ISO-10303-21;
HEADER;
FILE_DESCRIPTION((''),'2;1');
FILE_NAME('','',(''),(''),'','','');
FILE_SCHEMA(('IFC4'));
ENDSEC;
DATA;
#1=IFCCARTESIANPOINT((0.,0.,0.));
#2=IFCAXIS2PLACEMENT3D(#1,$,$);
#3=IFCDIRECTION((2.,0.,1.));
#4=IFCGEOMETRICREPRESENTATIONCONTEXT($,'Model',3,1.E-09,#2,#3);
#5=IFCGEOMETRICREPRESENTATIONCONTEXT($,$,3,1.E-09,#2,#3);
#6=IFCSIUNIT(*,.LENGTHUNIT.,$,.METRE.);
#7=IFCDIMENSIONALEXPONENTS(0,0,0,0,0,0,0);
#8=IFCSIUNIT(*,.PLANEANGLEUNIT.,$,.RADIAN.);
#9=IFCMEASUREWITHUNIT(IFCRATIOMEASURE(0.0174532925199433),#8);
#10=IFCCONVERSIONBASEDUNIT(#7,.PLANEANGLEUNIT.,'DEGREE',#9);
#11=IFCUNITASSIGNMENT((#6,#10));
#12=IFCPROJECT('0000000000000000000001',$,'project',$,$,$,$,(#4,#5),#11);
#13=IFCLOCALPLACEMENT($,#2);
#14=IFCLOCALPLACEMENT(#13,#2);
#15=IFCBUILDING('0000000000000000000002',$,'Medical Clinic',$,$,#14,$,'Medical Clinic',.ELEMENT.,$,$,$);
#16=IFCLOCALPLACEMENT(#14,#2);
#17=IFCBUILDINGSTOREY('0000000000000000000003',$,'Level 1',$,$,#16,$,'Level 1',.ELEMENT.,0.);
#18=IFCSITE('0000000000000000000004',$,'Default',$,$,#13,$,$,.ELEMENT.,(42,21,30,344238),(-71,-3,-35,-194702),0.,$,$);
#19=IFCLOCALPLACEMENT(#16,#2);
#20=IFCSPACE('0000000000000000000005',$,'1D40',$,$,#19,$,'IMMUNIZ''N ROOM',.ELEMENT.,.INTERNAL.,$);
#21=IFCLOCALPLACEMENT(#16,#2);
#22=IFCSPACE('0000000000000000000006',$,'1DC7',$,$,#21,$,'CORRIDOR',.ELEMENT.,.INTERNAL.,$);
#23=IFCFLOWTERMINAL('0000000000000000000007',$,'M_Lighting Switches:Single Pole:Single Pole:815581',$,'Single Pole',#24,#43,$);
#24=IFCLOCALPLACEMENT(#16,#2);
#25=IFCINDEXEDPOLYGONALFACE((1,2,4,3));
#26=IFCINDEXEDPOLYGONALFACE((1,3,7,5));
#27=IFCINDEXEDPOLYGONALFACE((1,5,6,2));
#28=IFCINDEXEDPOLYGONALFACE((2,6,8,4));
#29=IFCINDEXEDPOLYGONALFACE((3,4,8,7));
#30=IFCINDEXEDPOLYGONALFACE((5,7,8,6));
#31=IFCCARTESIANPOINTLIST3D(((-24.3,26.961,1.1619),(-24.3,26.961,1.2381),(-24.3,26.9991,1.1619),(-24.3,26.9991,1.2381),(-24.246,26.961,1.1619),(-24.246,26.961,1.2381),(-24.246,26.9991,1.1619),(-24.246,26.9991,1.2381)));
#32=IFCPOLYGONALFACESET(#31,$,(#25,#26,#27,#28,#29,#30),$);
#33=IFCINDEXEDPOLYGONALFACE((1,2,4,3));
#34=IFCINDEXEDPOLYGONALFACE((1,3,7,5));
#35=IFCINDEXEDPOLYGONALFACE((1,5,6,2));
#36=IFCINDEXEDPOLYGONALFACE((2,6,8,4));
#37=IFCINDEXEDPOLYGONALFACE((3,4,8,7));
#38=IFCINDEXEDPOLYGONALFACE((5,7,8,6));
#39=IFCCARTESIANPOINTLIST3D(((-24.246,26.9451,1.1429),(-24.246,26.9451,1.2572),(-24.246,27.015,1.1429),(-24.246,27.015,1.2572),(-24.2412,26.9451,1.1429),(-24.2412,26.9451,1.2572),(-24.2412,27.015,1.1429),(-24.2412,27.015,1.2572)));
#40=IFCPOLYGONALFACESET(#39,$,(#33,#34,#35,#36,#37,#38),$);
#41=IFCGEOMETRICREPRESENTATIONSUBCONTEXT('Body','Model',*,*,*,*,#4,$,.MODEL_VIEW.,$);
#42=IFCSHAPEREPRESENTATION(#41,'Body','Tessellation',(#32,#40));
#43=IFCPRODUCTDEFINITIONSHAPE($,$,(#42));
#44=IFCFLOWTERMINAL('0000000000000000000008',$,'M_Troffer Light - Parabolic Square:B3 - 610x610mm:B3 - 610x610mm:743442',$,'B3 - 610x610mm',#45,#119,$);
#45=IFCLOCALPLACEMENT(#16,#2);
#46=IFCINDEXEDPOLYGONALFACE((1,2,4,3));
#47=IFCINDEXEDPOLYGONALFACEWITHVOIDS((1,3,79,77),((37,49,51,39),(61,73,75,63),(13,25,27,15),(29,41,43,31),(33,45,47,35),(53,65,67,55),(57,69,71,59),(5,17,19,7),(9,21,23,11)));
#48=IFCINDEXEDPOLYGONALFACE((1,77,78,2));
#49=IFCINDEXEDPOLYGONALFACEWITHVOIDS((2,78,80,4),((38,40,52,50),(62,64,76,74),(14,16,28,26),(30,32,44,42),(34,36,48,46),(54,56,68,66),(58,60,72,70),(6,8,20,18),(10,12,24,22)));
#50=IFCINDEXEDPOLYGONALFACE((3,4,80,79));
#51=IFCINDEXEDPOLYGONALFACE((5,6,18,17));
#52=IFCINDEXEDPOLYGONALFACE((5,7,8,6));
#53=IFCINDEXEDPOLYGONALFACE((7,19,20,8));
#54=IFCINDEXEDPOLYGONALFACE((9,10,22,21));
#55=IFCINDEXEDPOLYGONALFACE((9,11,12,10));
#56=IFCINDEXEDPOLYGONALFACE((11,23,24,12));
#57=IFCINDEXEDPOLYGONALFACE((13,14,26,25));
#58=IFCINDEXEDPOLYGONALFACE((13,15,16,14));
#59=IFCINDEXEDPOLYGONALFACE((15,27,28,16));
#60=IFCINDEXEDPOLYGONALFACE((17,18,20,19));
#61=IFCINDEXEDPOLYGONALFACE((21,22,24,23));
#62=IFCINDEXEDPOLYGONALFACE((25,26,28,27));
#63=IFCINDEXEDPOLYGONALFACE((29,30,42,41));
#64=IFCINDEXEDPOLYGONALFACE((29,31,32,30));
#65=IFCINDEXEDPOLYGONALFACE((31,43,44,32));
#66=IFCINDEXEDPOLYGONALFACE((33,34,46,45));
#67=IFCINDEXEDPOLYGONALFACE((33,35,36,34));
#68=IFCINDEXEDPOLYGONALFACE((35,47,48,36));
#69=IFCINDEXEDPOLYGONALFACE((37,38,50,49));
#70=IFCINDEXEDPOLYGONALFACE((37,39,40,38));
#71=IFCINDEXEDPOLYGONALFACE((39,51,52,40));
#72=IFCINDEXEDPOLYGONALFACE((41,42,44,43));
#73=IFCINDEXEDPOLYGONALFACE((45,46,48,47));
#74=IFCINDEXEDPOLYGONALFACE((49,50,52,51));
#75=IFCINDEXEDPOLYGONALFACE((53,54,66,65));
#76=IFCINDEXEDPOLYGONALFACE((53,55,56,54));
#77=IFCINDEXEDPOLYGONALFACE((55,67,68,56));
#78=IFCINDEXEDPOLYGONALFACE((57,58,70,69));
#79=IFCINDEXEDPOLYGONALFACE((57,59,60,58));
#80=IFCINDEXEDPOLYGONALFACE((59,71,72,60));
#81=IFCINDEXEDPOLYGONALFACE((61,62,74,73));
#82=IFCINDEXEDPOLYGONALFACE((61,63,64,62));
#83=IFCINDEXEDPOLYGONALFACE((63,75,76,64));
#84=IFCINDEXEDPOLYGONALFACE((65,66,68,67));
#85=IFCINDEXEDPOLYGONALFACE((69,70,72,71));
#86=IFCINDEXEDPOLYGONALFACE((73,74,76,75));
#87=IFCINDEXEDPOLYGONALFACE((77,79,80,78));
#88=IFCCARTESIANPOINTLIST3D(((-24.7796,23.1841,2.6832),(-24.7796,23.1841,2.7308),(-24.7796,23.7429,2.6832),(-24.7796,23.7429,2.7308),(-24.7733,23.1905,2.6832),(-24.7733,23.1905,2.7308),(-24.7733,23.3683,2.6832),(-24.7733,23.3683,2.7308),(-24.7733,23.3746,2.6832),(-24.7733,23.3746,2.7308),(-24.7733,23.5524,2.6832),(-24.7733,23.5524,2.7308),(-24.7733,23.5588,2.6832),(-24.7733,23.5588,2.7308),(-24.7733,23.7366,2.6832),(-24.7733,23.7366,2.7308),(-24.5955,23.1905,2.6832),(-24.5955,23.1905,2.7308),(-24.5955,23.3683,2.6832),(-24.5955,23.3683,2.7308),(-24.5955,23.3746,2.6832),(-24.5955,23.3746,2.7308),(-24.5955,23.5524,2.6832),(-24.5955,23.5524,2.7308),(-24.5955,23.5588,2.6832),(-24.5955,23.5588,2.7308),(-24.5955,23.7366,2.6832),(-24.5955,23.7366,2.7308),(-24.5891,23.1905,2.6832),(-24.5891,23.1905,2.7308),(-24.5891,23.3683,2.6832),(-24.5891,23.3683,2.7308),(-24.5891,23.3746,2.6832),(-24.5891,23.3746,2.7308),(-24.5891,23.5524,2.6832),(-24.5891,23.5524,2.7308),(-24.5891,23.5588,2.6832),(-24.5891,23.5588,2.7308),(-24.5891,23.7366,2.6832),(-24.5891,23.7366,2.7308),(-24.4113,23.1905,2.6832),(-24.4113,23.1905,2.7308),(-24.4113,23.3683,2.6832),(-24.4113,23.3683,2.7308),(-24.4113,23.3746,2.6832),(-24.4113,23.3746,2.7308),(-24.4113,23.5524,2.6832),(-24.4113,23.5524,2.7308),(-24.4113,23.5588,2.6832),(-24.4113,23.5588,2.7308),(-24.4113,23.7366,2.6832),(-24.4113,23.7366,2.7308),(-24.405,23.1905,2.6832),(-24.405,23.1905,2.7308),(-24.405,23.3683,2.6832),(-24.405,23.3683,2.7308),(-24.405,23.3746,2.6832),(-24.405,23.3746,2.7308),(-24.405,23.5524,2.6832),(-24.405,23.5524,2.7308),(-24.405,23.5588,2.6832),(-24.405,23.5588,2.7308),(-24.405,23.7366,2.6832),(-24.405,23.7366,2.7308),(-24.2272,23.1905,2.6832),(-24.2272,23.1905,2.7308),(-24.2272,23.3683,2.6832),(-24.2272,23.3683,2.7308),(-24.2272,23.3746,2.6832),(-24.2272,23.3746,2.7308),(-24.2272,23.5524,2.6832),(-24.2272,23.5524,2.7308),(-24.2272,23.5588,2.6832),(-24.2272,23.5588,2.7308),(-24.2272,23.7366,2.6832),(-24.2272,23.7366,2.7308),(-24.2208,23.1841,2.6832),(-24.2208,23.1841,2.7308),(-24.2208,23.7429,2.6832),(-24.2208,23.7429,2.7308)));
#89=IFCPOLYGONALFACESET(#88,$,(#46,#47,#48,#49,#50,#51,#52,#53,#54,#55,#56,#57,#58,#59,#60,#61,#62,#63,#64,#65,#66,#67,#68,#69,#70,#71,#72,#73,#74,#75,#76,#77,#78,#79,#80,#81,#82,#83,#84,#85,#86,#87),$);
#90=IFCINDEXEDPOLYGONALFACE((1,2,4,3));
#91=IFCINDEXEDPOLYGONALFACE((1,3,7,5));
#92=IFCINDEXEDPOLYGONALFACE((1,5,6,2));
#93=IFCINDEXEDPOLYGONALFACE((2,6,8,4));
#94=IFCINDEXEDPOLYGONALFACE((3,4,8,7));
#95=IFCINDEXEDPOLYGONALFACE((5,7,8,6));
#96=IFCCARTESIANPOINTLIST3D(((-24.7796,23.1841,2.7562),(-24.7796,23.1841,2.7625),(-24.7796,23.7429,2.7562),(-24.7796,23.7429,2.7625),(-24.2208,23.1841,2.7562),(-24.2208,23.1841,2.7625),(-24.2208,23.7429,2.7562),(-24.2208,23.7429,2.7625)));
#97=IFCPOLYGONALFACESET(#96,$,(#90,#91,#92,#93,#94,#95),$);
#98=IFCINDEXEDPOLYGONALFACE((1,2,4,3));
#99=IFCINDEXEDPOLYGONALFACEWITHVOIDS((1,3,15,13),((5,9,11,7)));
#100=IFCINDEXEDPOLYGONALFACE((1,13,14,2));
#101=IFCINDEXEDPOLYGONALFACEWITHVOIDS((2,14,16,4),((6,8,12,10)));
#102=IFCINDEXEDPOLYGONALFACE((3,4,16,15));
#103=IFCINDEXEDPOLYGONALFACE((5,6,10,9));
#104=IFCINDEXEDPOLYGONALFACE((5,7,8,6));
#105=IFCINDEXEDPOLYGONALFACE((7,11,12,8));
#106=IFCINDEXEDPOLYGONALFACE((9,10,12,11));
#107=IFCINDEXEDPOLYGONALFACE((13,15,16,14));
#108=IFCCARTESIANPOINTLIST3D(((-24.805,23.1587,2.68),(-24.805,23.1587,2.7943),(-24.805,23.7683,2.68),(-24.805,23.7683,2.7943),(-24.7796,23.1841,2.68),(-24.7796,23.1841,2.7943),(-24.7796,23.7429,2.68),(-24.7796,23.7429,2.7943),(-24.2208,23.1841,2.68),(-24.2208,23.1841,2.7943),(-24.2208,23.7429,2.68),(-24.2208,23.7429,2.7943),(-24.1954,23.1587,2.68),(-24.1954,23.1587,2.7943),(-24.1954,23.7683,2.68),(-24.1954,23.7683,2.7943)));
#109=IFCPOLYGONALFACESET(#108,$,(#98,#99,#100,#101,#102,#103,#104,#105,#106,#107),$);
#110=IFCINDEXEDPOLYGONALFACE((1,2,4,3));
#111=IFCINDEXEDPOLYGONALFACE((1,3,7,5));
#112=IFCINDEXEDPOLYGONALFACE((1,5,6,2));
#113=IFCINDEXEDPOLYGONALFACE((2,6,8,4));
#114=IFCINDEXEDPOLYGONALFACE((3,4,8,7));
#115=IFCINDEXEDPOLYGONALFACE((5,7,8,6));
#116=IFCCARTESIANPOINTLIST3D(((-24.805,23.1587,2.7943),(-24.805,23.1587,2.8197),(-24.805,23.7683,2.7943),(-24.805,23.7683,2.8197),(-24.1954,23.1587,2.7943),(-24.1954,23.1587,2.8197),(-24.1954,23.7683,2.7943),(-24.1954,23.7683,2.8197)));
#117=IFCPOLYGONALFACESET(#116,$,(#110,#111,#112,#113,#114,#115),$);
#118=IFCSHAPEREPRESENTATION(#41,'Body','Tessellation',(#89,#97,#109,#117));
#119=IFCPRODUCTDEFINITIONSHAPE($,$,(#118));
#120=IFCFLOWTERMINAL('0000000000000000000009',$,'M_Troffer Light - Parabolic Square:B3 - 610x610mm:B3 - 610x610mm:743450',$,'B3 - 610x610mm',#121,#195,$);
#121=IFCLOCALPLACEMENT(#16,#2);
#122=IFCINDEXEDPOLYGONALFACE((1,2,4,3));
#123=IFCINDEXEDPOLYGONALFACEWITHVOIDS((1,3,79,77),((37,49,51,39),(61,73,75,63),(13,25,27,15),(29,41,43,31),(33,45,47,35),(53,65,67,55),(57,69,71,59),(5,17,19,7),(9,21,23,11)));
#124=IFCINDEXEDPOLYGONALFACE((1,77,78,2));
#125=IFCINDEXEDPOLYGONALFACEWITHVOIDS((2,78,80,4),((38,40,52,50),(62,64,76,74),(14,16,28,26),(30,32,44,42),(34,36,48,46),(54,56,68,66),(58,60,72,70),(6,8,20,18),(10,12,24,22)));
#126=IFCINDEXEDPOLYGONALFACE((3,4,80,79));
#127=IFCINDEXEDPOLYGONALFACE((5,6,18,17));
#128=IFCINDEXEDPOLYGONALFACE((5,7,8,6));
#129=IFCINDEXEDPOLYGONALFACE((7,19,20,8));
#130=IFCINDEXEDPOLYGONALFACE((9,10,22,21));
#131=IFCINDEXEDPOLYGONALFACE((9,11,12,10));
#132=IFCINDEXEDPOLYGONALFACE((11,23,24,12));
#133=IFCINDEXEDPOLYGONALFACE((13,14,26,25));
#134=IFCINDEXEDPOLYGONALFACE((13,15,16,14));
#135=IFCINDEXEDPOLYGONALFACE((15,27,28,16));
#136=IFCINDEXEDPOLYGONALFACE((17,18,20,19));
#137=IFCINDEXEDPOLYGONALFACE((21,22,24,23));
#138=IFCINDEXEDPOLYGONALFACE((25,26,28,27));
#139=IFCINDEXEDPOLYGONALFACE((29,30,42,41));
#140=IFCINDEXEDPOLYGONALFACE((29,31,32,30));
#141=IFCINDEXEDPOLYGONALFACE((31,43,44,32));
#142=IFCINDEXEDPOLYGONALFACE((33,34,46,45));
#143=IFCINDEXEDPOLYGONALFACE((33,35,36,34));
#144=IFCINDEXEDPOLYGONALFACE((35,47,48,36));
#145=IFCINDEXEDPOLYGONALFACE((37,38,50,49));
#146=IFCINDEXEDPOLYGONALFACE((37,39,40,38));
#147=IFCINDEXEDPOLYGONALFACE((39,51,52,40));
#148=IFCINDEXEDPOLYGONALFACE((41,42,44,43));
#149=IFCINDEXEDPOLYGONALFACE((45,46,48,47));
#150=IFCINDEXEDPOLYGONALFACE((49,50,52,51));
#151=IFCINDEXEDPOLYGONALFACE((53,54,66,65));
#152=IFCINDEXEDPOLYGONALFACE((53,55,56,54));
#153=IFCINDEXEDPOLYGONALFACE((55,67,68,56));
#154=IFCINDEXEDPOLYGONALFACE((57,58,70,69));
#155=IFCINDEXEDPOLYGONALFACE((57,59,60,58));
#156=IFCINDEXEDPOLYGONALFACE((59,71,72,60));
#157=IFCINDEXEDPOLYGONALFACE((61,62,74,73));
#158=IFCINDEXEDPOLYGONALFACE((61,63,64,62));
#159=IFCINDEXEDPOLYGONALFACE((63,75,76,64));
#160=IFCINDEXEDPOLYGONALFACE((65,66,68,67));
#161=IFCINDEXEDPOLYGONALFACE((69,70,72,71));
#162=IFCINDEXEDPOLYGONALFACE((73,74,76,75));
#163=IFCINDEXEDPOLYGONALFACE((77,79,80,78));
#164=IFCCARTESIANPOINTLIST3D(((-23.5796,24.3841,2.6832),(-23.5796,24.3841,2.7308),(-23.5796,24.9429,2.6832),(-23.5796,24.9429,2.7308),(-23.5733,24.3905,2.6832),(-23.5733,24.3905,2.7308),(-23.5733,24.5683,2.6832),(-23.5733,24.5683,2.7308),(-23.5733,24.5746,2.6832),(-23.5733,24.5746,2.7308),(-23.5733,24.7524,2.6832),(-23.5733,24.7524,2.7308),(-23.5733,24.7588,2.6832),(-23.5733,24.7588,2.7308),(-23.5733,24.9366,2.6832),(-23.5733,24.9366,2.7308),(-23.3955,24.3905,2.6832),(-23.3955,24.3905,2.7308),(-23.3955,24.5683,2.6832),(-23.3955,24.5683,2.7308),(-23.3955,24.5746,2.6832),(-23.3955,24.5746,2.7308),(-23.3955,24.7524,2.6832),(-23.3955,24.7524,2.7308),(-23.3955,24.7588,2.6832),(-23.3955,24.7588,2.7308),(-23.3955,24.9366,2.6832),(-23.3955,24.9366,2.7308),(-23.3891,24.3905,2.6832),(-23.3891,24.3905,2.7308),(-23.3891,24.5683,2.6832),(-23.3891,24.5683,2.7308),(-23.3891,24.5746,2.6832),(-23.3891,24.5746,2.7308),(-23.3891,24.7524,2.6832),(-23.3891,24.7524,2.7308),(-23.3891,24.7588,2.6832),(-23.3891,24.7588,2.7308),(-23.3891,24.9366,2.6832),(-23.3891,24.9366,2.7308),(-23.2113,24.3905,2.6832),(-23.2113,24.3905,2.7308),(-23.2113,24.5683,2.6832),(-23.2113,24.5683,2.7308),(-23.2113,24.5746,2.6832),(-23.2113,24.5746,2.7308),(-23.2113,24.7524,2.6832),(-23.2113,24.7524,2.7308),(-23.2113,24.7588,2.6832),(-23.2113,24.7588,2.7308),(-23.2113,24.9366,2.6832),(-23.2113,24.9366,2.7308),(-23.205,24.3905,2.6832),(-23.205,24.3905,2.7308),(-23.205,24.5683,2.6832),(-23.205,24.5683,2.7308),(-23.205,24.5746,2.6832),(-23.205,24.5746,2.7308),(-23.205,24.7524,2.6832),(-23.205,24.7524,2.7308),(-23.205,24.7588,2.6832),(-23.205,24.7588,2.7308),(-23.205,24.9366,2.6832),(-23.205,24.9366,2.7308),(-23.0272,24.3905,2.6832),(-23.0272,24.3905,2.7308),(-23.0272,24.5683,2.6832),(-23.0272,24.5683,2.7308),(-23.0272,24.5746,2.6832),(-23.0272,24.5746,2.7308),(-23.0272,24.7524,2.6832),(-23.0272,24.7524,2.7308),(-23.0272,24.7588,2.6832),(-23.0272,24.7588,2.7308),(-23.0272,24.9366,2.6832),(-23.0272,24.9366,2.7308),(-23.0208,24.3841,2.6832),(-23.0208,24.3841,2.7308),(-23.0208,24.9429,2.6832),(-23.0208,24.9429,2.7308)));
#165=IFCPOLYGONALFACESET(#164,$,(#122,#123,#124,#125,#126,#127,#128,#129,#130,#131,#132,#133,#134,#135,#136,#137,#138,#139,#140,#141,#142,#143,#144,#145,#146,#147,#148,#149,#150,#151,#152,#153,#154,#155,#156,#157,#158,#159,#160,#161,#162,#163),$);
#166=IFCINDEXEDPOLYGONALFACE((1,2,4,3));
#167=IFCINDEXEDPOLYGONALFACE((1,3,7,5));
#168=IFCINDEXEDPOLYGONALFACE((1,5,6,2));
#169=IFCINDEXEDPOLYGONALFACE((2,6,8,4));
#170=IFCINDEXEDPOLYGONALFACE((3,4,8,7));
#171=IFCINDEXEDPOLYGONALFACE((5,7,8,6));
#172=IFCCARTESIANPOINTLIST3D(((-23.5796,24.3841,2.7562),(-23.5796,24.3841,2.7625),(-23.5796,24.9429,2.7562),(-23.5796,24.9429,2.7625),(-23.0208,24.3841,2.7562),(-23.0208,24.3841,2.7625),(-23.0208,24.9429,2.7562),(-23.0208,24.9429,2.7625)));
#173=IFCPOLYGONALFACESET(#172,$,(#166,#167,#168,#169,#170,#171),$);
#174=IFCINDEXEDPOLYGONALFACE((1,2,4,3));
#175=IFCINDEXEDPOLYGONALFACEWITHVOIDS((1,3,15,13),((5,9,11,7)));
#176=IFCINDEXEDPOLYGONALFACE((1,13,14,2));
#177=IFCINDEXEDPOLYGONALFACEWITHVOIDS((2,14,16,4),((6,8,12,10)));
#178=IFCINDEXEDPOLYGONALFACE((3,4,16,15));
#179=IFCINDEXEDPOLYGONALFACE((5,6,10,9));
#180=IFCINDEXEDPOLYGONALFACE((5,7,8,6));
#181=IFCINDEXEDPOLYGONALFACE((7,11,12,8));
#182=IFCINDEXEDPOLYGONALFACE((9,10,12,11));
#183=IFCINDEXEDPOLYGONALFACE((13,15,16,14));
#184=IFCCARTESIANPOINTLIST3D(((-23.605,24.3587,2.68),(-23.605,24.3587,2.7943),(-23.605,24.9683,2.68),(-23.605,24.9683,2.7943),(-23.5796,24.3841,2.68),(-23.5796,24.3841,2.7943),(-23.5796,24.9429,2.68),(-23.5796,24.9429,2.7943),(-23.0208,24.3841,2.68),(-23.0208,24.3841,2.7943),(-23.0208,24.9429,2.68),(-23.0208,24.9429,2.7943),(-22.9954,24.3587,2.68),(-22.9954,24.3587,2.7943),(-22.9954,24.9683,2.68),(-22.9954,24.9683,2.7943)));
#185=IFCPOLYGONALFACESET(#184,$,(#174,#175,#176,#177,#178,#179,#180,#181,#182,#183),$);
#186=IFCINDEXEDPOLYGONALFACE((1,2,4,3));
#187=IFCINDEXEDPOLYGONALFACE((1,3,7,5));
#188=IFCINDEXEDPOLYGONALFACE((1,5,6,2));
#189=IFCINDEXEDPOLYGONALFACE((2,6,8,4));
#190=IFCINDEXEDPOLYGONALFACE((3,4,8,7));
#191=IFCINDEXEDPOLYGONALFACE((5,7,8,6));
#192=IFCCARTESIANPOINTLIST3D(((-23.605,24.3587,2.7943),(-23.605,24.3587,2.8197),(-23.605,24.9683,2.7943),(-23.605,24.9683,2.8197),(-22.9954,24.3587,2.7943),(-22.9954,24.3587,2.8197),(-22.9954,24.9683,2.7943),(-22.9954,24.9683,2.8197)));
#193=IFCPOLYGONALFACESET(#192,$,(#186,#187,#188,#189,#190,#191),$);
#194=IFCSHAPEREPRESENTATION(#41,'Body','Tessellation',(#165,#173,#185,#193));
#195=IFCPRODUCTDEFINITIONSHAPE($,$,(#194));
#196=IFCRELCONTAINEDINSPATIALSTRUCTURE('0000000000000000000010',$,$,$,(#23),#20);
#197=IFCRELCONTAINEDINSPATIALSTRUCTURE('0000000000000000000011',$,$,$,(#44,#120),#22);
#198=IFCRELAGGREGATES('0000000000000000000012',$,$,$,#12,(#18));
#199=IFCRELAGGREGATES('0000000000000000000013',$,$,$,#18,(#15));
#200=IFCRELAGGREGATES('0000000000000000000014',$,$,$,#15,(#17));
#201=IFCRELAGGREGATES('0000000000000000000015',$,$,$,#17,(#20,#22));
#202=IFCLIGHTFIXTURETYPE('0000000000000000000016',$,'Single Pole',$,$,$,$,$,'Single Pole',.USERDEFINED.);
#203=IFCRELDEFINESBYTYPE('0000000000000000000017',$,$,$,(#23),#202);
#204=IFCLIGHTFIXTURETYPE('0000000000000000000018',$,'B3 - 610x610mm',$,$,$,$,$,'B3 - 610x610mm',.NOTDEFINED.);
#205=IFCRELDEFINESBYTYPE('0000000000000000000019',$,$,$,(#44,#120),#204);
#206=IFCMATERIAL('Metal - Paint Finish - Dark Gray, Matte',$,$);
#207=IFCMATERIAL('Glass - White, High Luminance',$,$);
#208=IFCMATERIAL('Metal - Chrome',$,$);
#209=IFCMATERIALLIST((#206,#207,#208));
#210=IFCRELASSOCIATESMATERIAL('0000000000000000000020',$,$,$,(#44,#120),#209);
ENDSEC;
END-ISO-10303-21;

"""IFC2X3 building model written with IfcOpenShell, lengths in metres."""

from ifc_helpers import new_model, entity, si_unit, converted_unit, direction, frame, frame_2d, origin, origin_2d_with_axis, place, context, subcontext, project, spatial, polyline, rectangle, outline, extrude, source, transform, mapped, material, material_list, type_object, type_shapes, element, save


model = new_model("IFC2X3")

# Units and contexts
model_context = context("Model", 3, precision=1e-09, world=origin(), true_north=direction((2.0, 0.0, 1.0)))
context_of_model = context(None, 3, precision=1e-09, world=origin(), true_north=direction((2.0, 0.0, 1.0)))
body_context = subcontext(model_context, "Body", "Model", "MODEL_VIEW")
ifc_project = project(units=[si_unit("LENGTHUNIT", "METRE"), converted_unit("PLANEANGLEUNIT", "DEGREE", entity("IfcRatioMeasure", 0.0174532925199433), si_unit("PLANEANGLEUNIT", "RADIAN"), dimensions=[0, 0, 0, 0, 0, 0, 0])], contexts=[model_context, context_of_model])

# Site, building, storey
site_placement = place(None, origin())
site = spatial("IfcSite", under=ifc_project, at=site_placement, Name="Default", CompositionType="ELEMENT", RefLatitude=(42, 21, 30, 344238), RefLongitude=(-71, -3, -35, -194702), RefElevation=0.0)
building_placement = place(site_placement, origin())
building = spatial("IfcBuilding", under=site, at=building_placement, Name="Medical Clinic", LongName="Medical Clinic", CompositionType="ELEMENT")
storey_placement = place(building_placement, origin())
storey = spatial("IfcBuildingStorey", under=building, at=storey_placement, Name="Level 1", LongName="Level 1", CompositionType="ELEMENT", Elevation=0.0)

# Shared definitions
space_1_placement = place(storey_placement, origin())
space_1 = spatial("IfcSpace", under=storey, at=space_1_placement, Name="1D40", LongName="IMMUNIZ'N ROOM", CompositionType="ELEMENT", InteriorOrExteriorSpace="INTERNAL")

# Shared definitions
space_2_placement = place(storey_placement, origin())
space_2 = spatial("IfcSpace", under=storey, at=space_2_placement, Name="1DC7", LongName="CORRIDOR", CompositionType="ELEMENT", InteriorOrExteriorSpace="INTERNAL")

# Flow terminals
light_fixture_type_1 = type_object("IfcLightFixtureType", Name="Single Pole", ElementType="Single Pole", PredefinedType="USERDEFINED")
shared_shape_1 = source(origin(), body_context, "Body", "SweptSolid", [
    extrude(rectangle(XDim=0.0381, YDim=0.0762, at=origin_2d_with_axis()), frame((0.0, 0.0, -0.054), z_axis=(0.0, 0.0, 1.0), x_axis=(-1.0, 0.0, 0.0)), (0.0, 0.0, 1.0), 0.054),
    extrude(rectangle(XDim=0.0698, YDim=0.1143, at=frame_2d((0.0, 0.0), x_axis=(1.0, 0.0))), frame((0.0, 0.0, 0.0), z_axis=(0.0, 0.0, 1.0), x_axis=(-1.0, 0.0, 0.0)), (0.0, 0.0, 1.0), 0.0048),
])
type_shapes(light_fixture_type_1, [shared_shape_1])
flow_terminal_1_placement = place(space_1_placement, frame((-24.246, 26.9801, 1.2), z_axis=(1.0, 0.0, 0.0), x_axis=(0.0, 1.0, 0.0)))
element("IfcFlowTerminal", 1, at=flow_terminal_1_placement, inside=space_1, type_object=light_fixture_type_1, Name="M_Lighting Switches:Single Pole:Single Pole:815581", ObjectType="Single Pole", context=body_context, shape_type="MappedRepresentation", body=[
    mapped(shared_shape_1, transform((0.0, 0.0, 0.0), scale=1.0)),
])
ifc_material_1 = material(Name="Metal - Paint Finish - Dark Gray, Matte")
ifc_material_2 = material(Name="Glass - White, High Luminance")
ifc_material_3 = material(Name="Metal - Chrome")
ifc_material_list = material_list([ifc_material_1, ifc_material_2, ifc_material_3])
light_fixture_type_2 = type_object("IfcLightFixtureType", Name="B3 - 610x610mm", ElementType="B3 - 610x610mm", PredefinedType="NOTDEFINED")
shared_shape_2 = source(origin(), body_context, "Body", "SweptSolid", [
    extrude(outline(polyline([(-0.2794, -0.2794), (0.2794, -0.2794), (0.2794, 0.2794), (-0.2794, 0.2794), (-0.2794, -0.2794)]), holes=[polyline([(-0.0952, 0.0953), (-0.273, 0.0953), (-0.273, 0.2731), (-0.0952, 0.2731), (-0.0952, 0.0953)]), polyline([(0.2731, 0.0953), (0.0953, 0.0953), (0.0953, 0.2731), (0.2731, 0.2731), (0.2731, 0.0953)]), polyline([(-0.0889, 0.2731), (0.0889, 0.2731), (0.0889, 0.0953), (-0.0889, 0.0953), (-0.0889, 0.2731)]), polyline([(0.2731, -0.273), (0.0953, -0.273), (0.0953, -0.0952), (0.2731, -0.0952), (0.2731, -0.273)]), polyline([(0.0889, -0.273), (-0.0889, -0.273), (-0.0889, -0.0952), (0.0889, -0.0952), (0.0889, -0.273)]), polyline([(-0.0952, -0.273), (-0.273, -0.273), (-0.273, -0.0952), (-0.0952, -0.0952), (-0.0952, -0.273)]), polyline([(-0.0952, -0.0889), (-0.273, -0.0889), (-0.273, 0.0889), (-0.0952, 0.0889), (-0.0952, -0.0889)]), polyline([(0.0889, -0.0889), (-0.0889, -0.0889), (-0.0889, 0.0889), (0.0889, 0.0889), (0.0889, -0.0889)]), polyline([(0.2731, -0.0889), (0.0953, -0.0889), (0.0953, 0.0889), (0.2731, 0.0889), (0.2731, -0.0889)])]), frame((0.0, -0.3048, -0.0508), z_axis=(0.0, 0.0, 1.0), x_axis=(-1.0, 0.0, 0.0)), (0.0, 0.0, 1.0), 0.0476),
    extrude(rectangle(XDim=0.5588, YDim=0.5588, at=origin_2d_with_axis()), frame((0.0, -0.3048, -0.0825), z_axis=(0.0, 0.0, 1.0), x_axis=(-1.0, 0.0, 0.0)), (0.0, 0.0, 1.0), 0.0064),
    extrude(outline(polyline([(-0.3048, -0.3048), (0.3048, -0.3048), (0.3048, 0.3048), (-0.3048, 0.3048), (-0.3048, -0.3048)]), holes=[polyline([(0.2794, 0.2794), (0.2794, -0.2794), (-0.2794, -0.2794), (-0.2794, 0.2794), (0.2794, 0.2794)])]), frame((0.0, -0.3048, -0.1143)), (0.0, 0.0, 1.0), 0.1143),
    extrude(rectangle(XDim=0.6096, YDim=0.6096, at=origin_2d_with_axis()), frame((0.0, -0.3048, -0.1397), z_axis=(0.0, 0.0, 1.0), x_axis=(-1.0, 0.0, 0.0)), (0.0, 0.0, 1.0), 0.0254),
])
type_shapes(light_fixture_type_2, [shared_shape_2])
for number, where, z_axis, x_axis, name in (
    (2, (-24.5002, 23.1587, 2.68), (0.0, 0.0, -1.0), (1.0, 0.0, 0.0), "M_Troffer Light - Parabolic Square:B3 - 610x610mm:B3 - 610x610mm:743442"),
    (3, (-23.3002, 24.3587, 2.68), (0.0, 0.0, -1.0), (1.0, 0.0, 0.0), "M_Troffer Light - Parabolic Square:B3 - 610x610mm:B3 - 610x610mm:743450"),
):
    element("IfcFlowTerminal", number, at=place(space_2_placement, frame(where, z_axis=z_axis, x_axis=x_axis)), inside=space_2, type_object=light_fixture_type_2, material=ifc_material_list, Name=name, ObjectType="B3 - 610x610mm", context=body_context, shape_type="MappedRepresentation", body=[
        mapped(shared_shape_2, transform((0.0, 0.0, 0.0), scale=1.0)),
    ])

save(model, "model.ifc")
